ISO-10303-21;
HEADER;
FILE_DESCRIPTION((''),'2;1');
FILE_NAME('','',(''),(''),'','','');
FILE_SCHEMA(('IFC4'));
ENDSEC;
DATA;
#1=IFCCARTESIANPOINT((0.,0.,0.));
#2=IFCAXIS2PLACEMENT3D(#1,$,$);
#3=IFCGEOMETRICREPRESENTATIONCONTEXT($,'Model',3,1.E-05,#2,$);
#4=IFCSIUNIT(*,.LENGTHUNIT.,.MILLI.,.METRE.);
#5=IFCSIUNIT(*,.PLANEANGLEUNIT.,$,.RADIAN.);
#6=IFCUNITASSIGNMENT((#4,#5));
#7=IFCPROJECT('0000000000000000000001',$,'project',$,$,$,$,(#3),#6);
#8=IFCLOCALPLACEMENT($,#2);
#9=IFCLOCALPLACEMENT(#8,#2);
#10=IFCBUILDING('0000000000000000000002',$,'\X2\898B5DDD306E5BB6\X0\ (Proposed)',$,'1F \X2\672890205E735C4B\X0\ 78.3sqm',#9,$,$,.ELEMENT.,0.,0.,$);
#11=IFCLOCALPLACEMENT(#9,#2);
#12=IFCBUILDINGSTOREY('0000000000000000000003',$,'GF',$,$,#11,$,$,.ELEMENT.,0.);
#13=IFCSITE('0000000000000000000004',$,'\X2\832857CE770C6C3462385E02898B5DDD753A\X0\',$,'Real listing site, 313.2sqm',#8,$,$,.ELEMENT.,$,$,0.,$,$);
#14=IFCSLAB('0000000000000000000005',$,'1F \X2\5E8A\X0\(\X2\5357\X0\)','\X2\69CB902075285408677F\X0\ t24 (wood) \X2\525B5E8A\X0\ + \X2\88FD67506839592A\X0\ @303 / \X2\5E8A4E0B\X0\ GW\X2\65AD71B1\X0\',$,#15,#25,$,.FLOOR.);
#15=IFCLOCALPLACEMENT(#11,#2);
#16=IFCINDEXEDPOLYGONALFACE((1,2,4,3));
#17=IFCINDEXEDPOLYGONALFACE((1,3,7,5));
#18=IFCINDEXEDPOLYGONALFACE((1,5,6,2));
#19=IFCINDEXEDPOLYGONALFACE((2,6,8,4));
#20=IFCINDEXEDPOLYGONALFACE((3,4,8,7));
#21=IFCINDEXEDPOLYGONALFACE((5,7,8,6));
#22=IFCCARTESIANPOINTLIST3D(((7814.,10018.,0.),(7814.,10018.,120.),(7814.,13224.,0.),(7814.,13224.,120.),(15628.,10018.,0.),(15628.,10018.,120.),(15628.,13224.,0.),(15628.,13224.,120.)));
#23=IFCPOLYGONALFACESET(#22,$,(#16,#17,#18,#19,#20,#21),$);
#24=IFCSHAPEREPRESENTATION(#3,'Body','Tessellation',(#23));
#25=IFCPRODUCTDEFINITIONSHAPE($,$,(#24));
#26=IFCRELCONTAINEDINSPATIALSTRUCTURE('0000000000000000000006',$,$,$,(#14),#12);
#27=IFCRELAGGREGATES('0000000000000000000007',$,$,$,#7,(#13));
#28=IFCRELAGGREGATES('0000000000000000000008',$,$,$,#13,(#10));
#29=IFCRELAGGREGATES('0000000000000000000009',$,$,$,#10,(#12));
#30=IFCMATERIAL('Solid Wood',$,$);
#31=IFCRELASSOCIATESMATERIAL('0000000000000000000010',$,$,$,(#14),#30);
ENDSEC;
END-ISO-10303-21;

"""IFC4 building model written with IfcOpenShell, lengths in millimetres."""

from ifc_helpers import new_model, si_unit, frame, frame_2d, origin, place, context, project, spatial, rectangle, extrude, material, element, save


model = new_model("IFC4")

# Units and contexts
model_context = context("Model", 3, precision=1e-05, world=origin())
ifc_project = project(units=[si_unit("LENGTHUNIT", "METRE", prefix="MILLI"), si_unit("PLANEANGLEUNIT", "RADIAN")], contexts=[model_context])

# Site, building, storey
site_placement = place(None, origin())
site = spatial("IfcSite", under=ifc_project, at=site_placement, Name="茨城県水戸市見川町", ObjectType="Real listing site, 313.2sqm", CompositionType="ELEMENT", RefElevation=0.0)
building_placement = place(site_placement, origin())
building = spatial("IfcBuilding", under=site, at=building_placement, Name="見川の家 (Proposed)", ObjectType="1F 木造平屋 78.3sqm", CompositionType="ELEMENT", ElevationOfRefHeight=0.0, ElevationOfTerrain=0.0)
storey_placement = place(building_placement, origin())
storey = spatial("IfcBuildingStorey", under=building, at=storey_placement, Name="GF", CompositionType="ELEMENT", Elevation=0.0)

# Slab
ifc_material_1 = material(Name="Solid Wood")
slab_1_placement = place(storey_placement, frame((3907.0, 5009.0, 0.0)))
element("IfcSlab", 1, at=slab_1_placement, inside=storey, material=ifc_material_1, Name="1F 床(南)", Description="構造用合板 t24 (wood) 剛床 + 製材根太 @303 / 床下 GW断熱", PredefinedType="FLOOR", context=model_context, shape_type="SweptSolid", body=[
    extrude(rectangle(XDim=7814.0, YDim=3206.0, at=frame_2d((3907.0, 1603.0))), frame((3907.0, 5009.0, 0.0)), (0.0, 0.0, 1.0), 120.0),
])

save(model, "model.ifc")
